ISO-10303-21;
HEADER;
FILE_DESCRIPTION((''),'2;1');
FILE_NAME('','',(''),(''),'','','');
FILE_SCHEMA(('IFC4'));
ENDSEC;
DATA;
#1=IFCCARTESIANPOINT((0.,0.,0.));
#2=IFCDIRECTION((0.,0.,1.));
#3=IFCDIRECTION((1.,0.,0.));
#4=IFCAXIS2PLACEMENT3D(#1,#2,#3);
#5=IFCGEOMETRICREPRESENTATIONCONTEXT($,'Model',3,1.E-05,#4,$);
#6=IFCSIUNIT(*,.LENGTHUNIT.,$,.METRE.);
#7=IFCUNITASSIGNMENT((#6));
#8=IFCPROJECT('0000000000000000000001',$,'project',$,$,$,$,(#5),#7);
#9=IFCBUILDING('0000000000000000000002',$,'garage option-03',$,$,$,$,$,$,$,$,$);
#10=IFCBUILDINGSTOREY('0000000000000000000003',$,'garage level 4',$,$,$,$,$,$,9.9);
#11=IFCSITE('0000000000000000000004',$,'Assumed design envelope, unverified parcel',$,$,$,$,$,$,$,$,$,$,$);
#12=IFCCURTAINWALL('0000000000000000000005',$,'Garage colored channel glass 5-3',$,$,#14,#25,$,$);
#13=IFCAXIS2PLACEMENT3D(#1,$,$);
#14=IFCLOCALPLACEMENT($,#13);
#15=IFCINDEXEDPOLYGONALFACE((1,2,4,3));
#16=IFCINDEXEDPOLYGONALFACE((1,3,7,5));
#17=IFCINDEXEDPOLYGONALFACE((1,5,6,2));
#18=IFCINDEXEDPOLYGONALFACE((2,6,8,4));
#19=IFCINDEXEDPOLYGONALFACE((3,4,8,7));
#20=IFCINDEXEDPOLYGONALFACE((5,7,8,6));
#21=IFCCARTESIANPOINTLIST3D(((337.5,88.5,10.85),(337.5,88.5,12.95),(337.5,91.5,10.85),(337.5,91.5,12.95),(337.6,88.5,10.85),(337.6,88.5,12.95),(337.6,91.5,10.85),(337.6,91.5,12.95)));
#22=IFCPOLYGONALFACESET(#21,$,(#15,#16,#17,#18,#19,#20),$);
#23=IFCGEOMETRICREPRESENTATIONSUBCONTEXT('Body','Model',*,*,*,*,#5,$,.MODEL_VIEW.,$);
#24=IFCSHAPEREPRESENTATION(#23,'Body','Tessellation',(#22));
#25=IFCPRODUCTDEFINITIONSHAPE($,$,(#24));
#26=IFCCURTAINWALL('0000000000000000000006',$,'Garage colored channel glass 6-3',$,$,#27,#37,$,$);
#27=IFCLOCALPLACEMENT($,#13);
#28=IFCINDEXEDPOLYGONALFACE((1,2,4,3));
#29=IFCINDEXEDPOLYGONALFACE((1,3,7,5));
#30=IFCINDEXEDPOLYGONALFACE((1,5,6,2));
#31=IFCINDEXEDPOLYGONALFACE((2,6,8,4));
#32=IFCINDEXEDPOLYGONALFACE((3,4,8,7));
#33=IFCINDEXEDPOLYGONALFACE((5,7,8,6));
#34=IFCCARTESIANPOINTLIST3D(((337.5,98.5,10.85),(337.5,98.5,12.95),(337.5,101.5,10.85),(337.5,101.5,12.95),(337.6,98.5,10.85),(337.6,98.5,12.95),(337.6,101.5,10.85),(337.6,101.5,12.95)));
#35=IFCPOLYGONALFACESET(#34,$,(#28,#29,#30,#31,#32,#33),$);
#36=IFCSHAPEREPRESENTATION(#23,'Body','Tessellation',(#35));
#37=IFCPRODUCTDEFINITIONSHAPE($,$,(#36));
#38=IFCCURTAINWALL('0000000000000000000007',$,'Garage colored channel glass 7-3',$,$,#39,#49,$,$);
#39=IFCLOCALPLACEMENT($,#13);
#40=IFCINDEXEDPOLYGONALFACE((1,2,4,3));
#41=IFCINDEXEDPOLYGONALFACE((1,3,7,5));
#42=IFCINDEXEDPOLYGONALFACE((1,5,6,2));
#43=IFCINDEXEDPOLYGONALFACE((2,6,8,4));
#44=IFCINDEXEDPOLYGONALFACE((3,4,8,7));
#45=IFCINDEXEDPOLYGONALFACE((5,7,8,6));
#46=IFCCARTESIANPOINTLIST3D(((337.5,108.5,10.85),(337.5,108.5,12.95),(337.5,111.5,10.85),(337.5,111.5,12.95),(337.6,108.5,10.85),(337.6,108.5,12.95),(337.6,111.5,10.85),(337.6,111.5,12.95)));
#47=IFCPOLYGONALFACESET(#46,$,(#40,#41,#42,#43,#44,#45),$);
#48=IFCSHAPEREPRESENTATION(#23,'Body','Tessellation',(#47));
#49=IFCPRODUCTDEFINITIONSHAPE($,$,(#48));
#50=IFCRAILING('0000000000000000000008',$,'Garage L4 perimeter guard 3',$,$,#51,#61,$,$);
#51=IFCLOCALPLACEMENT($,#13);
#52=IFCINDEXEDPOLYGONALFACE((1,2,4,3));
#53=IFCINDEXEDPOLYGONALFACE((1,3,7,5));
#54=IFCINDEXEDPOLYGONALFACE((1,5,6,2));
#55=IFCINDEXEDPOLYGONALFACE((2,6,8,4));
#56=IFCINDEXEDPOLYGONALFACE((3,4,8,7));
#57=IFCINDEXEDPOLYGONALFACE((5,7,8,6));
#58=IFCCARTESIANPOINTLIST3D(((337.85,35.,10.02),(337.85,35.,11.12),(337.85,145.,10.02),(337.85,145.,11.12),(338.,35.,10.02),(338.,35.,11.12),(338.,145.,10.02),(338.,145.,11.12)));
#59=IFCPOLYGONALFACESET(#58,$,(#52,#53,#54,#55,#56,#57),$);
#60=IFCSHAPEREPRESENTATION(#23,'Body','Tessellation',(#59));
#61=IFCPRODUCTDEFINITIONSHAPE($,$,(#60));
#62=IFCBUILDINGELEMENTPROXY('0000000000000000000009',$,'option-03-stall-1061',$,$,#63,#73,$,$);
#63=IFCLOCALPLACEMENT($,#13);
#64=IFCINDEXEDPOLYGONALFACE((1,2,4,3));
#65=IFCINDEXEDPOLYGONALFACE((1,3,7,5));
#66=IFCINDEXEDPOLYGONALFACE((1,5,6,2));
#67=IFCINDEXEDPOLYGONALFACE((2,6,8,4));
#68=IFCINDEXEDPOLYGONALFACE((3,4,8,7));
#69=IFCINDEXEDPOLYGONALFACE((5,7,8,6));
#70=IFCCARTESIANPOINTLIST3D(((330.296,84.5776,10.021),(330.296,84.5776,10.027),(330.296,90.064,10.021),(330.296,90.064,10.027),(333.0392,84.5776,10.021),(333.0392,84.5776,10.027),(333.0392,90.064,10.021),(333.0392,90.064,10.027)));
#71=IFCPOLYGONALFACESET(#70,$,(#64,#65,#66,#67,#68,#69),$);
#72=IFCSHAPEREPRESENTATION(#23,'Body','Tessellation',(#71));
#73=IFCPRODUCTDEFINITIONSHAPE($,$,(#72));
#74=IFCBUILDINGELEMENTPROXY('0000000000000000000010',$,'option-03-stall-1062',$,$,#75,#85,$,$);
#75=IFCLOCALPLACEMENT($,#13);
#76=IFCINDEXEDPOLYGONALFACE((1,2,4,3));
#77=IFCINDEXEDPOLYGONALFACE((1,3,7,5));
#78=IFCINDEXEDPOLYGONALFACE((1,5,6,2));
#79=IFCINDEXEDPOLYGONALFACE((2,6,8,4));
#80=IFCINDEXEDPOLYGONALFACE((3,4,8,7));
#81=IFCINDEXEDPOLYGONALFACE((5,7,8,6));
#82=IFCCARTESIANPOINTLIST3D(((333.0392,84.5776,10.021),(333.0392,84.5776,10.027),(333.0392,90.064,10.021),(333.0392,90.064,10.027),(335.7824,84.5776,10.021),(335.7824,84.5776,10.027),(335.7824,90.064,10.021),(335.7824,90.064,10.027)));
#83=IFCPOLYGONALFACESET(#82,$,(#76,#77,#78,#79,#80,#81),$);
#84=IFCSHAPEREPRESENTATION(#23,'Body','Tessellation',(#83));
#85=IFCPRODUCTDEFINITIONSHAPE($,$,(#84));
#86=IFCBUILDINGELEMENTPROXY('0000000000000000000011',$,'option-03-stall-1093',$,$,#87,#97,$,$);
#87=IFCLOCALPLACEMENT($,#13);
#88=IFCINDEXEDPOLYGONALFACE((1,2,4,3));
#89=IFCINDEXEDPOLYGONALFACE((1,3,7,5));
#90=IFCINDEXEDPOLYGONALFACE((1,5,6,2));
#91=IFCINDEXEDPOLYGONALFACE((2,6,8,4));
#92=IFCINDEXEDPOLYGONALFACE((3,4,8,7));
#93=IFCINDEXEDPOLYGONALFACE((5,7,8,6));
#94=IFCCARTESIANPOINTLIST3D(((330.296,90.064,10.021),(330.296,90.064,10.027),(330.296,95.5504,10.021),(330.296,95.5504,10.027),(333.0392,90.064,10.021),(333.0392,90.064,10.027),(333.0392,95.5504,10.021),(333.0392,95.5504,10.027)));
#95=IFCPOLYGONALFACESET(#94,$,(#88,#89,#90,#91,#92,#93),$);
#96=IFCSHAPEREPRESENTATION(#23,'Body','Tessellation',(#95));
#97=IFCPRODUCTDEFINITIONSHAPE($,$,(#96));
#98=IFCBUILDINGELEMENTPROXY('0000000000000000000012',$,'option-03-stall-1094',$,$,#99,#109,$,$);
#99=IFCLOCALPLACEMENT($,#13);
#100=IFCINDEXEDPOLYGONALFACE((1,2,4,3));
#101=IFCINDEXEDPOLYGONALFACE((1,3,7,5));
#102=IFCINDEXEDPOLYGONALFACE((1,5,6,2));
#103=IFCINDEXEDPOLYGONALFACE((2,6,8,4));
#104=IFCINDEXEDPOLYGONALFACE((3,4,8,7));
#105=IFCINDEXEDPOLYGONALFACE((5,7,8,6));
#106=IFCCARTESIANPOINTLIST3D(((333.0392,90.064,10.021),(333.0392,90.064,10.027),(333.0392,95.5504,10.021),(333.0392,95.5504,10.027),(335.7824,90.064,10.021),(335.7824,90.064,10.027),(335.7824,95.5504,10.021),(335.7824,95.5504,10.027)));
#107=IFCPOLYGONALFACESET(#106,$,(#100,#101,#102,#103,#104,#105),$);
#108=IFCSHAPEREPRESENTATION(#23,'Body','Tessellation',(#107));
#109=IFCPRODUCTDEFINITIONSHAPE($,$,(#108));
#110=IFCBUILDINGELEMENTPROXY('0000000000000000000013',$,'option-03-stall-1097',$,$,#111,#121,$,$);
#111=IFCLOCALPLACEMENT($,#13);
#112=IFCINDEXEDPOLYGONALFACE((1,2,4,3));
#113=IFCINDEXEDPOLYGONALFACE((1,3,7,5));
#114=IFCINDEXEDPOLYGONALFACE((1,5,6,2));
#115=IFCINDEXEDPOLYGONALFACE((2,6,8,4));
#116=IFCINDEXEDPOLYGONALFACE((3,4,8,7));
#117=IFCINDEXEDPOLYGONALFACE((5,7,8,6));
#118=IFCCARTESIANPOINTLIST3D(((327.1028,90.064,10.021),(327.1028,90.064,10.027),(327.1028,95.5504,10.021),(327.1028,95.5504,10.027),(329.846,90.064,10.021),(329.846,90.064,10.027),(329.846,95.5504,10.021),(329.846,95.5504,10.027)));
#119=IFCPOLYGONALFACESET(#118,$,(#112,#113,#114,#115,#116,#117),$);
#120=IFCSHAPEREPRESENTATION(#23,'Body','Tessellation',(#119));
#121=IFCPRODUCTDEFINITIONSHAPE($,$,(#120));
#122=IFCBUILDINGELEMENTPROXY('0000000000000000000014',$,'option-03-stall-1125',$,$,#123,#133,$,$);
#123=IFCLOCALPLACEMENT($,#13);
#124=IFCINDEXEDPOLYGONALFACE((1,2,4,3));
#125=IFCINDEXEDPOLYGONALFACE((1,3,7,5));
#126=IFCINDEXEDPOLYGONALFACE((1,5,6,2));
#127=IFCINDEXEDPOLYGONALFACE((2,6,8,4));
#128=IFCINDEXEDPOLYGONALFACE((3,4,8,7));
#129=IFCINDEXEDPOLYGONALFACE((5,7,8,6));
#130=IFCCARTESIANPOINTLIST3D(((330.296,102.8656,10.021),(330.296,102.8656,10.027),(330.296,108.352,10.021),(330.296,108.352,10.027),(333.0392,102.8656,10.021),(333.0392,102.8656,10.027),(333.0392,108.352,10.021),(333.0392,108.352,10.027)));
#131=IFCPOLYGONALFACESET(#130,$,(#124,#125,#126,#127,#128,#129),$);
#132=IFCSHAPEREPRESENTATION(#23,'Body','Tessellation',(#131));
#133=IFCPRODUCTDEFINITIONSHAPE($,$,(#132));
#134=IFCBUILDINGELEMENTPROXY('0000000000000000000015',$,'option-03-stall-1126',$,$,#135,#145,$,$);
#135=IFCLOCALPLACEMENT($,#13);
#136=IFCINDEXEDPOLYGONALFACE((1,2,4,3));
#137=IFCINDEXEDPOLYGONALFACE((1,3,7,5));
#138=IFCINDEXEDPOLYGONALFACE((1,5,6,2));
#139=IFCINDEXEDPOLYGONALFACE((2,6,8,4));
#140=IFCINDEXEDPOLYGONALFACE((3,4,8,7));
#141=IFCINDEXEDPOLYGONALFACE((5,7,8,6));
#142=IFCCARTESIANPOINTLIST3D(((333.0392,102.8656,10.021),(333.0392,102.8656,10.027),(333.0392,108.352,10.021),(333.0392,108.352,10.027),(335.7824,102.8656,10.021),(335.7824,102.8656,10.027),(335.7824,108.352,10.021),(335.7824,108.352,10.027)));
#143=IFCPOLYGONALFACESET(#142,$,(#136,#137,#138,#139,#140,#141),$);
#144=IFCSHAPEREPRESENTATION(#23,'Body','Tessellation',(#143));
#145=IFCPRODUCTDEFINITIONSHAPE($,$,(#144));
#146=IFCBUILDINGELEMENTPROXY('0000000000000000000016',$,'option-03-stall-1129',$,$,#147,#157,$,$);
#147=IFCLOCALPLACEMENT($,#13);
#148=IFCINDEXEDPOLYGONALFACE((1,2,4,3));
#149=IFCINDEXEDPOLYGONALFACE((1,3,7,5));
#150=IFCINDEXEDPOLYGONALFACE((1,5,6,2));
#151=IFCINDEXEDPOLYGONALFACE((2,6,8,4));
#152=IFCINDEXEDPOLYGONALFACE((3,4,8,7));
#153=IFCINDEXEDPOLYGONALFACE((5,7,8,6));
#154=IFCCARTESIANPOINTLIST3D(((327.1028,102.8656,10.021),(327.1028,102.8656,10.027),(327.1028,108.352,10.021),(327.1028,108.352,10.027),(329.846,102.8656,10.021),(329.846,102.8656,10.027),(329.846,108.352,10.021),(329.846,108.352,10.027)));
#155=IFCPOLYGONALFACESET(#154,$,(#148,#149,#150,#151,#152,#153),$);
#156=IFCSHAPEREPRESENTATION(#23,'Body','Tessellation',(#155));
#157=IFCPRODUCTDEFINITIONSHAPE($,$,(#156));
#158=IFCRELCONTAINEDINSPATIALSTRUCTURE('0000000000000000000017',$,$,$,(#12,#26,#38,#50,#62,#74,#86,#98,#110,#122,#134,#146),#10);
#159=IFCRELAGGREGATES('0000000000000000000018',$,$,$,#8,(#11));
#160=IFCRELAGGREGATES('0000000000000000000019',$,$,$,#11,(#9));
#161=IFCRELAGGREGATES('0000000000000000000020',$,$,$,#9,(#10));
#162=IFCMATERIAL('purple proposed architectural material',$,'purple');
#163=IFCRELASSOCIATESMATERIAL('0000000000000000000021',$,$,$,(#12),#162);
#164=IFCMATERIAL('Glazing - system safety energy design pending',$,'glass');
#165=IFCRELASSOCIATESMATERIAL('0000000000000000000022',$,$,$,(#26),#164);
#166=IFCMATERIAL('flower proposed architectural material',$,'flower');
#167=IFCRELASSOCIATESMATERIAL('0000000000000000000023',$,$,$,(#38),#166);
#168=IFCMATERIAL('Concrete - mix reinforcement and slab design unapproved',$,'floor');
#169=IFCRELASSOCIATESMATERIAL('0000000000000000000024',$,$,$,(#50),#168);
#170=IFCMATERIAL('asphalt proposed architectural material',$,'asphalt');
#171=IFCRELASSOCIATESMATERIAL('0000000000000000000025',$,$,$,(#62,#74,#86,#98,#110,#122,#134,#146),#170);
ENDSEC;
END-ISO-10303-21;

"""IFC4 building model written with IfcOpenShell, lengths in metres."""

from ifc_helpers import new_model, si_unit, frame, origin_with_axes, place, context, subcontext, project, spatial, rectangle, extrude, material, element, save


model = new_model("IFC4")

# Units and contexts
model_context = context("Model", 3, precision=1e-05, world=origin_with_axes())
body_context = subcontext(model_context, "Body", "Model", "MODEL_VIEW")
ifc_project = project(units=[si_unit("LENGTHUNIT", "METRE")], contexts=[model_context])

# Site, building, storey
site = spatial("IfcSite", under=ifc_project, Name="Assumed design envelope, unverified parcel")
building = spatial("IfcBuilding", under=site, Name="garage option-03")
storey = spatial("IfcBuildingStorey", under=building, Name="garage level 4", Elevation=9.9)

# Shared definitions
ifc_material_1 = material(Name="Concrete - mix reinforcement and slab design unapproved", Category="floor")

# Curtain walls
ifc_material_2 = material(Name="purple proposed architectural material", Category="purple")
curtain_wall_1_placement = place(None, frame((337.55, 90.0, 10.85), z_axis=(0.0, 0.0, 1.0), x_axis=(1.0, 0.0, 0.0)))
element("IfcCurtainWall", 1, at=curtain_wall_1_placement, inside=storey, material=ifc_material_2, Name="Garage colored channel glass 5-3", context=body_context, shape_type="SweptSolid", body=[
    extrude(rectangle(XDim=0.1, YDim=3.0), origin_with_axes(), (0.0, 0.0, 1.0), 2.1),
])
ifc_material_3 = material(Name="Glazing - system safety energy design pending", Category="glass")
curtain_wall_2_placement = place(None, frame((337.55, 100.0, 10.85), z_axis=(0.0, 0.0, 1.0), x_axis=(1.0, 0.0, 0.0)))
element("IfcCurtainWall", 2, at=curtain_wall_2_placement, inside=storey, material=ifc_material_3, Name="Garage colored channel glass 6-3", context=body_context, shape_type="SweptSolid", body=[
    extrude(rectangle(XDim=0.1, YDim=3.0), origin_with_axes(), (0.0, 0.0, 1.0), 2.1),
])
ifc_material_4 = material(Name="flower proposed architectural material", Category="flower")
curtain_wall_3_placement = place(None, frame((337.55, 110.0, 10.85), z_axis=(0.0, 0.0, 1.0), x_axis=(1.0, 0.0, 0.0)))
element("IfcCurtainWall", 3, at=curtain_wall_3_placement, inside=storey, material=ifc_material_4, Name="Garage colored channel glass 7-3", context=body_context, shape_type="SweptSolid", body=[
    extrude(rectangle(XDim=0.1, YDim=3.0), origin_with_axes(), (0.0, 0.0, 1.0), 2.1),
])

# Railing
railing_placement = place(None, frame((337.925, 90.0, 10.02), z_axis=(0.0, 0.0, 1.0), x_axis=(1.0, 0.0, 0.0)))
element("IfcRailing", 4, at=railing_placement, inside=storey, material=ifc_material_1, Name="Garage L4 perimeter guard 3", context=body_context, shape_type="SweptSolid", body=[
    extrude(rectangle(XDim=0.15, YDim=110.0), origin_with_axes(), (0.0, 0.0, 1.0), 1.1),
])

# Building element proxies
ifc_material_5 = material(Name="asphalt proposed architectural material", Category="asphalt")
for number, where, z_axis, x_axis, name in (
    (5, (331.6676, 87.3208, 10.021), (0.0, 0.0, 1.0), (1.0, 0.0, 0.0), "option-03-stall-1061"),
    (6, (334.4108, 87.3208, 10.021), (0.0, 0.0, 1.0), (1.0, 0.0, 0.0), "option-03-stall-1062"),
    (7, (331.6676, 92.8072, 10.021), (0.0, 0.0, 1.0), (1.0, 0.0, 0.0), "option-03-stall-1093"),
    (8, (334.4108, 92.8072, 10.021), (0.0, 0.0, 1.0), (1.0, 0.0, 0.0), "option-03-stall-1094"),
    (9, (328.4744, 92.8072, 10.021), (0.0, 0.0, 1.0), (1.0, 0.0, 0.0), "option-03-stall-1097"),
    (10, (331.6676, 105.6088, 10.021), (0.0, 0.0, 1.0), (1.0, 0.0, 0.0), "option-03-stall-1125"),
    (11, (334.4108, 105.6088, 10.021), (0.0, 0.0, 1.0), (1.0, 0.0, 0.0), "option-03-stall-1126"),
    (12, (328.4744, 105.6088, 10.021), (0.0, 0.0, 1.0), (1.0, 0.0, 0.0), "option-03-stall-1129"),
):
    element("IfcBuildingElementProxy", number, at=place(None, frame(where, z_axis=z_axis, x_axis=x_axis)), inside=storey, material=ifc_material_5, Name=name, context=body_context, shape_type="SweptSolid", body=[
        extrude(rectangle(XDim=2.7432, YDim=5.4864), origin_with_axes(), (0.0, 0.0, 1.0), 0.006),
    ])

save(model, "model.ifc")
